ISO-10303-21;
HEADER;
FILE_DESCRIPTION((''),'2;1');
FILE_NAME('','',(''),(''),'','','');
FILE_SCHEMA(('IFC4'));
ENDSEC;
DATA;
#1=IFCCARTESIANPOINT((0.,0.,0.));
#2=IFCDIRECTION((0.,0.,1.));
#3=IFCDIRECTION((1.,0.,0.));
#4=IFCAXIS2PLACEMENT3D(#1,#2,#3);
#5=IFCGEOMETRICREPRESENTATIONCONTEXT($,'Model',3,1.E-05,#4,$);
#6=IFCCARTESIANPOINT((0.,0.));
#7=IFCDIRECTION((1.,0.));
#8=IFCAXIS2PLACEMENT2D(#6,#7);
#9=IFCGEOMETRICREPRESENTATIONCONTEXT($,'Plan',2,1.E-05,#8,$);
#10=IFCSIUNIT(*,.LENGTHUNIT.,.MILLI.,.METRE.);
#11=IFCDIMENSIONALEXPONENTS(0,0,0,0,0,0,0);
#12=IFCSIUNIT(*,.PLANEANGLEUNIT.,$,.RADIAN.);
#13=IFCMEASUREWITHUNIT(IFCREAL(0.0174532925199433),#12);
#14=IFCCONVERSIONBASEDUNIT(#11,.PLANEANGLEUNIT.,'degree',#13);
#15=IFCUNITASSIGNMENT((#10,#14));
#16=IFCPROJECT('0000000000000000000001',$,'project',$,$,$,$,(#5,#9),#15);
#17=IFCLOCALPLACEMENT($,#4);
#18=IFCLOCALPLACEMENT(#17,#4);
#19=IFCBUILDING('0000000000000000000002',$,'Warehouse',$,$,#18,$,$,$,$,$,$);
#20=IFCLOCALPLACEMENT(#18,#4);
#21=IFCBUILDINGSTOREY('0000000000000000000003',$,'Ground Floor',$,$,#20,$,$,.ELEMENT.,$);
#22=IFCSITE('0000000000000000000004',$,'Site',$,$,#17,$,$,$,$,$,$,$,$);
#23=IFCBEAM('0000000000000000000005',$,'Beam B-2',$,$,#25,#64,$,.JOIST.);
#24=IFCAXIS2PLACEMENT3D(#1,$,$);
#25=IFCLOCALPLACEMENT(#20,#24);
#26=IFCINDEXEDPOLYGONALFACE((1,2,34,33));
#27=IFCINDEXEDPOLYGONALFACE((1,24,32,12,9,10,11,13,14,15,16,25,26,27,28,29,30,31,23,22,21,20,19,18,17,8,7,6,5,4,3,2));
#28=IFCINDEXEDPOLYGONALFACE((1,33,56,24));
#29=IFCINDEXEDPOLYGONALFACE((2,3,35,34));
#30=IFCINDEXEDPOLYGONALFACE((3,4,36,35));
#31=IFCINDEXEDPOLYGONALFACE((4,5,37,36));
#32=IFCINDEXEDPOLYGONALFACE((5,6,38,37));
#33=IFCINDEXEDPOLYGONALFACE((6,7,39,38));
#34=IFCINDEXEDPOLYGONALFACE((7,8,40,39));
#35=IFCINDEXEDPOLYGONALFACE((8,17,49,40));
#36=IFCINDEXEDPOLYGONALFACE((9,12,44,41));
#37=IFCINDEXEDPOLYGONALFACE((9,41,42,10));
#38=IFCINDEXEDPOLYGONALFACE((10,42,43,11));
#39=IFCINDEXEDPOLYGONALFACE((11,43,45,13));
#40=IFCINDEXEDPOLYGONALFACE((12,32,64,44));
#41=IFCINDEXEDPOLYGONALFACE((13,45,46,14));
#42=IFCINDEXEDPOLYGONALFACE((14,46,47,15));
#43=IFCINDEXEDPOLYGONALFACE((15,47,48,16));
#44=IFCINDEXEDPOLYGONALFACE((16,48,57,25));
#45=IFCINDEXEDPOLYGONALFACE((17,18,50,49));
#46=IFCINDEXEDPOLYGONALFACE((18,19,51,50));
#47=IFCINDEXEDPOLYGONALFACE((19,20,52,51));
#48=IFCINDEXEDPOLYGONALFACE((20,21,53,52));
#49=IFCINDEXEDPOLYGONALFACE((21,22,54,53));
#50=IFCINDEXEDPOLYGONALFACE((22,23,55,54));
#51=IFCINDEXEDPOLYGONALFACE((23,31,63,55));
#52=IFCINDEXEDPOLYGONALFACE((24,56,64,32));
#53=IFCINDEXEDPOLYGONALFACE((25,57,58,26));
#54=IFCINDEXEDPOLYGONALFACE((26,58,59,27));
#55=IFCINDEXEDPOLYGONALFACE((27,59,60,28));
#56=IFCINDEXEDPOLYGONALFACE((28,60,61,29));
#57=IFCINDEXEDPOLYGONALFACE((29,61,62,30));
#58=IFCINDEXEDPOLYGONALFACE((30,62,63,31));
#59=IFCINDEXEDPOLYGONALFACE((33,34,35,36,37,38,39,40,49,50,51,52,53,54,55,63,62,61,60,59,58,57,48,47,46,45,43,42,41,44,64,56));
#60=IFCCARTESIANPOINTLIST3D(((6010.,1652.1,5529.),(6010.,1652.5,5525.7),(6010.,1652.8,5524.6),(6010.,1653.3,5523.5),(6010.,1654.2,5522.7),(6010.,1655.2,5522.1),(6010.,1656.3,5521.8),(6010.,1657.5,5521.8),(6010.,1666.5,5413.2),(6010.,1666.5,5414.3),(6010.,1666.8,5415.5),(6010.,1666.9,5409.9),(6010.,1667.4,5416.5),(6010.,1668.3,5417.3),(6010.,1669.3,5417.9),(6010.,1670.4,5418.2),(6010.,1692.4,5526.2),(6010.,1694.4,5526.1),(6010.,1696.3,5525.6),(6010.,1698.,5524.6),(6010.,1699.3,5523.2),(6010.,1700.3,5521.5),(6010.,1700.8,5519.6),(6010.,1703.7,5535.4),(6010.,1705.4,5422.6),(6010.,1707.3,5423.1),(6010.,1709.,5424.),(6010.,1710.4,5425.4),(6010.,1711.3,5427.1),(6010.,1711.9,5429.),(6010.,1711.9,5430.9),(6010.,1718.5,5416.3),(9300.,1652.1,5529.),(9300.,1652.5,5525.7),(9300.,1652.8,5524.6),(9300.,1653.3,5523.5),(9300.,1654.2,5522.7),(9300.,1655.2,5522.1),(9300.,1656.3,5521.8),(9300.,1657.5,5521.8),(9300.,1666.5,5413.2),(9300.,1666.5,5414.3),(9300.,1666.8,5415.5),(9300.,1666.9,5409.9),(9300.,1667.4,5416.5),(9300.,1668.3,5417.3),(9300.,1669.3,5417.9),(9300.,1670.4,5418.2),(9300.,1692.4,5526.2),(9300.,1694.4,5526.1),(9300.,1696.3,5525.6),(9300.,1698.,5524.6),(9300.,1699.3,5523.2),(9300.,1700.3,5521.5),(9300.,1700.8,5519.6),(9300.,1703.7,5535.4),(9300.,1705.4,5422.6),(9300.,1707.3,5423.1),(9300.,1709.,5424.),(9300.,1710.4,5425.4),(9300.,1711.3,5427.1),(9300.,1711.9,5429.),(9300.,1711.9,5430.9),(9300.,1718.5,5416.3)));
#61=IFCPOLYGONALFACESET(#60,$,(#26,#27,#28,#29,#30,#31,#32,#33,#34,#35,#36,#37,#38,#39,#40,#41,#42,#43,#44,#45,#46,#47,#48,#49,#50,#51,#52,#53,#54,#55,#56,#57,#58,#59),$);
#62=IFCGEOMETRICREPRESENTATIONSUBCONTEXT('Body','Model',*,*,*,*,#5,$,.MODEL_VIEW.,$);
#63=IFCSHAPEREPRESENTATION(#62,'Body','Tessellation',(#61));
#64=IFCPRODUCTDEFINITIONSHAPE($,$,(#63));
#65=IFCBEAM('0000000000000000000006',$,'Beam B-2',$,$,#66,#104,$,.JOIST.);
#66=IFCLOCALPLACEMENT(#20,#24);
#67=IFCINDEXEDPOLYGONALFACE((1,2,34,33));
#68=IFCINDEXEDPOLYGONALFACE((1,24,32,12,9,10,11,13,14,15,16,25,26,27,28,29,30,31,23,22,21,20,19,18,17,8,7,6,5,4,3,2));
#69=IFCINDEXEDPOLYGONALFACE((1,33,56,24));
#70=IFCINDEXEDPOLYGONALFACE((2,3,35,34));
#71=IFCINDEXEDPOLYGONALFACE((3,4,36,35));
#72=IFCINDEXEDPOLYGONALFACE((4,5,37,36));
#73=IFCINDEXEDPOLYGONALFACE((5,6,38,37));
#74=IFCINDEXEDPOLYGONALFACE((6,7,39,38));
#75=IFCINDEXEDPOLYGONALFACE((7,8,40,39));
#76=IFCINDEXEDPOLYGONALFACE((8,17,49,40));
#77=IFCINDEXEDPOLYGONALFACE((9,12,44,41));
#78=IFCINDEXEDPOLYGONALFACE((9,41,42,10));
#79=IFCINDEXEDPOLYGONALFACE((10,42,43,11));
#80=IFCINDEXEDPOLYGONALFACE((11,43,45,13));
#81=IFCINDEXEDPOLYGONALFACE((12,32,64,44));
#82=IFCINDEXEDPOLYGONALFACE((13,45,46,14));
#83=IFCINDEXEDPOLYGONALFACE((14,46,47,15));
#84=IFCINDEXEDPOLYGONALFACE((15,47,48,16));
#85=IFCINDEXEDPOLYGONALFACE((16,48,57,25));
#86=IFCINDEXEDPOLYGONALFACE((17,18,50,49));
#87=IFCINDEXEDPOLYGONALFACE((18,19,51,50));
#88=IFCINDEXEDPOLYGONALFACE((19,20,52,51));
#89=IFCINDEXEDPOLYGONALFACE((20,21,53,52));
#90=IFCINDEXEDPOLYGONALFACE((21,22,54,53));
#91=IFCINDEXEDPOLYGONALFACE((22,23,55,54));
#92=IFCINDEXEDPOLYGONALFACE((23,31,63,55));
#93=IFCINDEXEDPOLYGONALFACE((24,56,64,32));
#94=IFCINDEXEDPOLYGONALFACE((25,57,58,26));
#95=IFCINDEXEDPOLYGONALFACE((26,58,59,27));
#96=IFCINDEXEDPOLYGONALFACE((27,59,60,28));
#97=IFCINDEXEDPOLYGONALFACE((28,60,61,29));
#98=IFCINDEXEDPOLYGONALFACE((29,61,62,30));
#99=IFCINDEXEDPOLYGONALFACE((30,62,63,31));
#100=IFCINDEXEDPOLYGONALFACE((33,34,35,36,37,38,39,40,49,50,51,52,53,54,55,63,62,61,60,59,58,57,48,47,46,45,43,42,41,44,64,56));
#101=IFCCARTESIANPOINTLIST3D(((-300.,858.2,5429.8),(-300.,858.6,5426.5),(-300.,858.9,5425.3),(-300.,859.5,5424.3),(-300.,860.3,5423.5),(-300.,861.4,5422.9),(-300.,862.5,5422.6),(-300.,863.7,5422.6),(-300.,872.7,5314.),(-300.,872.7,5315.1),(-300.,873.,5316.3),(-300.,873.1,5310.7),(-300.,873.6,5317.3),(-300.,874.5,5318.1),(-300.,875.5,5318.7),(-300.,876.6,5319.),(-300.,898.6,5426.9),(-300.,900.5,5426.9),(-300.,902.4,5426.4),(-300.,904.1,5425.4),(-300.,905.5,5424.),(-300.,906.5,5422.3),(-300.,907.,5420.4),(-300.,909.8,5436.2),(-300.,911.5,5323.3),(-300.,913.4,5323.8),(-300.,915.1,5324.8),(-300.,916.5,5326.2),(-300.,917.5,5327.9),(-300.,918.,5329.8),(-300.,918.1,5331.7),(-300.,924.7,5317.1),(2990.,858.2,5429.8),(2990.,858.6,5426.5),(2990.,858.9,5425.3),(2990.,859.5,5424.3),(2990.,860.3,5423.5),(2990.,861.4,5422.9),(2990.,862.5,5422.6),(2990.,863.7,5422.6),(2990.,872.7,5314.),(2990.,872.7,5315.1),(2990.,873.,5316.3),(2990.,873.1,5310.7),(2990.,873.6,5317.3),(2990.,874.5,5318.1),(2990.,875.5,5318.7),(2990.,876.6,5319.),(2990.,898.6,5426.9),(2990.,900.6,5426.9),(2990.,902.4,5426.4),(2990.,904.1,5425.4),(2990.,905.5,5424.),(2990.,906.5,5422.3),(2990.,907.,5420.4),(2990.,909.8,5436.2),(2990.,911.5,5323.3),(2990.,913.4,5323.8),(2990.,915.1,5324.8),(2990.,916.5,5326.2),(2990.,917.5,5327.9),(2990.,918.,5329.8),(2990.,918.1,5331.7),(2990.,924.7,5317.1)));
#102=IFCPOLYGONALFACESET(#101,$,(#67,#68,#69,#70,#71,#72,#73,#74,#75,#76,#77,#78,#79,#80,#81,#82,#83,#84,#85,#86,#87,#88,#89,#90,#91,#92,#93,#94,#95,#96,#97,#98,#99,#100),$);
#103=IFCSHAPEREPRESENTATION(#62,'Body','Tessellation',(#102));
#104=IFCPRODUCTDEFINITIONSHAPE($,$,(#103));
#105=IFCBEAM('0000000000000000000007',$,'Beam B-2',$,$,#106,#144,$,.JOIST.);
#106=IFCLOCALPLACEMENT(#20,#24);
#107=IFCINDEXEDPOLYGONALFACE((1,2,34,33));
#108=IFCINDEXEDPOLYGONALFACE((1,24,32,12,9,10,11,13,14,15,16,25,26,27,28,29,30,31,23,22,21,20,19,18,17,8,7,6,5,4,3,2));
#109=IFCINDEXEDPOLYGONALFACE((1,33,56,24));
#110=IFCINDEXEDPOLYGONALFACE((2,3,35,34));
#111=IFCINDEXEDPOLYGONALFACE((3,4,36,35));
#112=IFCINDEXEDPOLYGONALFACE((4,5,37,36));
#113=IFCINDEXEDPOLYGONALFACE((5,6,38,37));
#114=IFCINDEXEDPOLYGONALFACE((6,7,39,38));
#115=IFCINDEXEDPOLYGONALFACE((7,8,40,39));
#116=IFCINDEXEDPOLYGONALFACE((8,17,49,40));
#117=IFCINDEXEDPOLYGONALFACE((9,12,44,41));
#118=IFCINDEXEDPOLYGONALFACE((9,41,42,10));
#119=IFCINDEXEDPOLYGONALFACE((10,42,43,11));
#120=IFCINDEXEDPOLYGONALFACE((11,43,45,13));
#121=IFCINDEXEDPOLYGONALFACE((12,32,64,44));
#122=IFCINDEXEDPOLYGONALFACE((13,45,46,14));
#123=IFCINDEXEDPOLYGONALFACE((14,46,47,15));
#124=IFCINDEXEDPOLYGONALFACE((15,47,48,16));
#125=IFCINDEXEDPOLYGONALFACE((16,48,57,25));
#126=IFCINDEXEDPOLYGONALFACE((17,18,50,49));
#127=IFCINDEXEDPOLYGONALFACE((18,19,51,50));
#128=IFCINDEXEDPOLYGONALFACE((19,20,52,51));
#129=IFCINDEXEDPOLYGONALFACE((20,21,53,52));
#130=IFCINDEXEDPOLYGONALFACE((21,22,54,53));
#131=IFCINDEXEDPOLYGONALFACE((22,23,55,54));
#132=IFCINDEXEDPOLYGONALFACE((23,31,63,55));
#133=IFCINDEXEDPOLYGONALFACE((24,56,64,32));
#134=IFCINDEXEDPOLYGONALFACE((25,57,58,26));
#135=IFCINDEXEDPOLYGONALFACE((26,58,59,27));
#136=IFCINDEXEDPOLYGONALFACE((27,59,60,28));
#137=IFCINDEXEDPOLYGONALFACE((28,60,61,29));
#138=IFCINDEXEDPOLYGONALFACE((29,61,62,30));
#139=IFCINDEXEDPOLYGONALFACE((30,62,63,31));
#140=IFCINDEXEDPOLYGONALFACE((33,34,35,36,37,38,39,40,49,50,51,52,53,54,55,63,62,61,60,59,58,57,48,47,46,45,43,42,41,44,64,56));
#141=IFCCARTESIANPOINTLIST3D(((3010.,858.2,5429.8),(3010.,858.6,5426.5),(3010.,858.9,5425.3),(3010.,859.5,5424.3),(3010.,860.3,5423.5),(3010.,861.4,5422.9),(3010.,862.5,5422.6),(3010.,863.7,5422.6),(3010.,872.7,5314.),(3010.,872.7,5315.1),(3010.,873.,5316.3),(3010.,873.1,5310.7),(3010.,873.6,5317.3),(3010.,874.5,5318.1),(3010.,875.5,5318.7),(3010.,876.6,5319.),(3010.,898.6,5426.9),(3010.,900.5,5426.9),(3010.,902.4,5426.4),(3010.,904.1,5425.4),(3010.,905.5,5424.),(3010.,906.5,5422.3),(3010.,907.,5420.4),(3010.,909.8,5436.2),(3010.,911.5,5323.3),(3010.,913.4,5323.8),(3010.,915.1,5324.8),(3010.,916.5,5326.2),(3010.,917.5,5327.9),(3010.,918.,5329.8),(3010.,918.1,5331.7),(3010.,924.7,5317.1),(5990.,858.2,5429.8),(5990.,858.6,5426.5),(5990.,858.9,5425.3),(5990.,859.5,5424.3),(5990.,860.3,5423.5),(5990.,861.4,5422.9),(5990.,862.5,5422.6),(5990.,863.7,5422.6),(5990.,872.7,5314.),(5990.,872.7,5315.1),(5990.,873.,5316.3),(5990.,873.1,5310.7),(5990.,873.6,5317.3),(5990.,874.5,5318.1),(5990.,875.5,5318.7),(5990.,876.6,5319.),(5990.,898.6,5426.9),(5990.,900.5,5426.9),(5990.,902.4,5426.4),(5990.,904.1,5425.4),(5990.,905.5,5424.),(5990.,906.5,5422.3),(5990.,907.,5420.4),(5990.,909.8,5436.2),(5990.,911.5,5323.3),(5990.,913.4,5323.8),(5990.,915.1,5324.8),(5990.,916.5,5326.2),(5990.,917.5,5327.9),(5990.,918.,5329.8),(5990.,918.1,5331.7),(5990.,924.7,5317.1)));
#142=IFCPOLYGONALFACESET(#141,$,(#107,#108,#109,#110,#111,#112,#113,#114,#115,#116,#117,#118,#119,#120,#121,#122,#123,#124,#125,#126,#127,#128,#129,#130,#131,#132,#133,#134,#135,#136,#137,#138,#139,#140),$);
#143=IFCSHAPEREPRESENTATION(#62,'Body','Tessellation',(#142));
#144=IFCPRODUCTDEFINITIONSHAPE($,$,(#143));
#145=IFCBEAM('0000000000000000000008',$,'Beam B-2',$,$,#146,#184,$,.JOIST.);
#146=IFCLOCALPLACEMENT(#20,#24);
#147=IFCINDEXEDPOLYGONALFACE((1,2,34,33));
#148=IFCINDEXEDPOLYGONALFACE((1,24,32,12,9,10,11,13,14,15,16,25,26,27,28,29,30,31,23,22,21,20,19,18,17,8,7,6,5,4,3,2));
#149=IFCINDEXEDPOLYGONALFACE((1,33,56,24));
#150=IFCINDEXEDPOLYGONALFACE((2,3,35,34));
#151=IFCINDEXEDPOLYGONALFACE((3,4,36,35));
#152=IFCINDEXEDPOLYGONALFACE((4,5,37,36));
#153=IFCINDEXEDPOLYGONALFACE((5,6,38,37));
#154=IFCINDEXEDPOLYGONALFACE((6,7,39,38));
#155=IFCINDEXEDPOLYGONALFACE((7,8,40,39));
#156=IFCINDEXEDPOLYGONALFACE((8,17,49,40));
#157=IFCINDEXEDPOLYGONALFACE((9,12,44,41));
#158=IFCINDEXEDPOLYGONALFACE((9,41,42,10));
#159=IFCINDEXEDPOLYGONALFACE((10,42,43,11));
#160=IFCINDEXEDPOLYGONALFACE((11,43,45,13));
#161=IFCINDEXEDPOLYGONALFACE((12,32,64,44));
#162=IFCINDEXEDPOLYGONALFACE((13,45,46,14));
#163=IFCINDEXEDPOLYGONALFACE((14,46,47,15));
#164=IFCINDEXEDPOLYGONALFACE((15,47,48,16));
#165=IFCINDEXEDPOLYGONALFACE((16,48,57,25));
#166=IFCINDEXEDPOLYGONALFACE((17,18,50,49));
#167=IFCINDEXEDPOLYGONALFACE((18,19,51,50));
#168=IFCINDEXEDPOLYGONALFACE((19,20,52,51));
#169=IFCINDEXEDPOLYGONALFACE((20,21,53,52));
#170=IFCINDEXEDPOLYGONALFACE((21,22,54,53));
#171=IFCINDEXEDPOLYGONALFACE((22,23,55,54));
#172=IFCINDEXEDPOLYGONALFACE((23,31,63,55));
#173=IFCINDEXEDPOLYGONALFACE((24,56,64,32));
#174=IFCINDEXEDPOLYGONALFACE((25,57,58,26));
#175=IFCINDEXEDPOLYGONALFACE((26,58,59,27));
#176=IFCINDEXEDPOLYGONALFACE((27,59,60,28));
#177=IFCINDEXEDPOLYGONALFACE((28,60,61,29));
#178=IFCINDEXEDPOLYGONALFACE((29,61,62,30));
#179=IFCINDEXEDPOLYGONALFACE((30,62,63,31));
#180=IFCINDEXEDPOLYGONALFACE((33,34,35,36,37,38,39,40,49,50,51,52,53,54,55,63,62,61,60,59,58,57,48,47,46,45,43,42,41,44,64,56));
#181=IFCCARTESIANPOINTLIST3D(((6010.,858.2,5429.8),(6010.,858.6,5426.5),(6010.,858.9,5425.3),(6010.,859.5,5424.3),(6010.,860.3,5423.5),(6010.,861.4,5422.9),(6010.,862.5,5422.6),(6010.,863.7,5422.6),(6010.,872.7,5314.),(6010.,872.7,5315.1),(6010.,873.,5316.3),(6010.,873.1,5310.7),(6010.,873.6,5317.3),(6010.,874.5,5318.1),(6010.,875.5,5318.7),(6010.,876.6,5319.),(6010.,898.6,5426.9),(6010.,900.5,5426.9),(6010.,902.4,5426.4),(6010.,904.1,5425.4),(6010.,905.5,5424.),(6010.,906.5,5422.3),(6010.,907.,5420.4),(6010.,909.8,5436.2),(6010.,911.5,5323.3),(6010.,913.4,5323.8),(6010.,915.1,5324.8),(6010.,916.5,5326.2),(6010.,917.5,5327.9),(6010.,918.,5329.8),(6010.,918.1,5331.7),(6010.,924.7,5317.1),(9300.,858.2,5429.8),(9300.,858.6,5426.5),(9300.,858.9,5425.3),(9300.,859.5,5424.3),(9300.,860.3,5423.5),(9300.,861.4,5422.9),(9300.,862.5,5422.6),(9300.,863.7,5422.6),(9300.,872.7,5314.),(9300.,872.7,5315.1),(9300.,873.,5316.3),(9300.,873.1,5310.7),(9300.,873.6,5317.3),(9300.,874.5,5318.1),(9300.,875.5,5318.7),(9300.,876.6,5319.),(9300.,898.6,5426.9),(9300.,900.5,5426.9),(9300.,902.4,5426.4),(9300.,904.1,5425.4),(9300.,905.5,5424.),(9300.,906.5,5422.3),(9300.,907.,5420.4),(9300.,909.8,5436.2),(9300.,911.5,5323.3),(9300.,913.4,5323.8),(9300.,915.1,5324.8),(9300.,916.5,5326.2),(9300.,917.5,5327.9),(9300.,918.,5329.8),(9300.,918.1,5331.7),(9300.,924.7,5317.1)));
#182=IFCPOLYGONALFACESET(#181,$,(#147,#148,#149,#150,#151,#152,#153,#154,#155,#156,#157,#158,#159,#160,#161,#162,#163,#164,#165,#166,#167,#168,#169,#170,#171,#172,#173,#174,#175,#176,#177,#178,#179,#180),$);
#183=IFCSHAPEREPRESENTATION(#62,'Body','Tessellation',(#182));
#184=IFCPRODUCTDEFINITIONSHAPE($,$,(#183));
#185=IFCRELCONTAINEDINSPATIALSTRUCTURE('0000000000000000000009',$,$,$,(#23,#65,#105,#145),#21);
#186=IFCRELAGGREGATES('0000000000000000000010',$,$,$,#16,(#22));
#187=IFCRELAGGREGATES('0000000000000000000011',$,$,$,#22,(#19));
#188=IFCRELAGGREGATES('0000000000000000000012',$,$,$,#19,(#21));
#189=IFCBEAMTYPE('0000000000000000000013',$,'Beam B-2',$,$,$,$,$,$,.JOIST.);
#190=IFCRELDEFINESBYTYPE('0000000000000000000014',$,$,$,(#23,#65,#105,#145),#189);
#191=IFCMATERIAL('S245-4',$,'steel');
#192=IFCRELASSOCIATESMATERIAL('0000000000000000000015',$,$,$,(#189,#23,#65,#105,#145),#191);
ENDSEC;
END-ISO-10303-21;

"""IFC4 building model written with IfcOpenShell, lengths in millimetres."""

from ifc_helpers import new_model, entity, si_unit, converted_unit, frame, origin_with_axes, origin_2d_with_axis, place, context, subcontext, project, spatial, u_section, extrude, material, material_profile, profile_set, profile_usage, type_object, element, save


model = new_model("IFC4")

# Units and contexts
model_context = context("Model", 3, precision=1e-05, world=origin_with_axes())
plan_context = context("Plan", 2, precision=1e-05, world=origin_2d_with_axis())
body_context = subcontext(model_context, "Body", "Model", "MODEL_VIEW")
ifc_project = project(units=[si_unit("LENGTHUNIT", "METRE", prefix="MILLI"), converted_unit("PLANEANGLEUNIT", "degree", entity("IfcReal", 0.0174532925199433), si_unit("PLANEANGLEUNIT", "RADIAN"), dimensions=[0, 0, 0, 0, 0, 0, 0])], contexts=[model_context, plan_context])

# Site, building, storey
site_placement = place(None, origin_with_axes())
site = spatial("IfcSite", under=ifc_project, at=site_placement, Name="Site")
building_placement = place(site_placement, origin_with_axes())
building = spatial("IfcBuilding", under=site, at=building_placement, Name="Warehouse")
storey_placement = place(building_placement, origin_with_axes())
storey = spatial("IfcBuildingStorey", under=building, at=storey_placement, Name="Ground Floor", CompositionType="ELEMENT")

# Beams
ifc_material_1 = material(Name="S245-4", Category="steel")
ifc_material_profile_1 = material_profile(ifc_material_1, u_section(Depth=120.0, FlangeWidth=52.0, WebThickness=4.8, FlangeThickness=7.8, FilletRadius=7.5, EdgeRadius=4.5, FlangeSlope=0.0))
ifc_profile_set_1 = profile_set([ifc_material_profile_1], Name="U12P_S245-4")
beam_type_1 = type_object("IfcBeamType", Name="Beam B-2", PredefinedType="JOIST", material=ifc_profile_set_1)
ifc_profile_usage_1 = profile_usage(ifc_profile_set_1, cardinal=3)
beam_1_placement = place(storey_placement, frame((9300.0, 1718.5, 5416.3), z_axis=(-1.0, 0.0, 0.0), x_axis=(0.0, -0.99228, -0.12402)))
element("IfcBeam", 1, at=beam_1_placement, inside=storey, type_object=beam_type_1, material=ifc_profile_usage_1, Name="Beam B-2", PredefinedType="JOIST", context=body_context, shape_type="SweptSolid", body=[
    extrude(u_section(Depth=120.0, FlangeWidth=52.0, WebThickness=4.8, FlangeThickness=7.8, FilletRadius=7.5, EdgeRadius=4.5, FlangeSlope=0.0), frame((26.0, 60.0, 0.0), z_axis=(0.0, 0.0, 1.0), x_axis=(1.0, 0.0, 0.0)), (0.0, 0.0, 1.0), 3290.0),
])
ifc_profile_usage_2 = profile_usage(ifc_profile_set_1, cardinal=3)
beam_2_placement = place(storey_placement, frame((2990.0, 924.7, 5317.1), z_axis=(-1.0, 0.0, 0.0), x_axis=(0.0, -0.99228, -0.124019)))
element("IfcBeam", 2, at=beam_2_placement, inside=storey, type_object=beam_type_1, material=ifc_profile_usage_2, Name="Beam B-2", PredefinedType="JOIST", context=body_context, shape_type="SweptSolid", body=[
    extrude(u_section(Depth=120.0, FlangeWidth=52.0, WebThickness=4.8, FlangeThickness=7.8, FilletRadius=7.5, EdgeRadius=4.5, FlangeSlope=0.0), frame((26.0, 60.0, 0.0), z_axis=(0.0, 0.0, 1.0), x_axis=(1.0, 0.0, 0.0)), (0.0, 0.0, 1.0), 3290.0),
])
ifc_profile_usage_3 = profile_usage(ifc_profile_set_1, cardinal=3)
beam_3_placement = place(storey_placement, frame((5990.0, 924.7, 5317.1), z_axis=(-1.0, 0.0, 0.0), x_axis=(0.0, -0.99228, -0.12402)))
element("IfcBeam", 3, at=beam_3_placement, inside=storey, type_object=beam_type_1, material=ifc_profile_usage_3, Name="Beam B-2", PredefinedType="JOIST", context=body_context, shape_type="SweptSolid", body=[
    extrude(u_section(Depth=120.0, FlangeWidth=52.0, WebThickness=4.8, FlangeThickness=7.8, FilletRadius=7.5, EdgeRadius=4.5, FlangeSlope=0.0), frame((26.0, 60.0, 0.0), z_axis=(0.0, 0.0, 1.0), x_axis=(1.0, 0.0, 0.0)), (0.0, 0.0, 1.0), 2980.0),
])
ifc_profile_usage_4 = profile_usage(ifc_profile_set_1, cardinal=3)
beam_4_placement = place(storey_placement, frame((9300.0, 924.7, 5317.1), z_axis=(-1.0, 0.0, 0.0), x_axis=(0.0, -0.99228, -0.12402)))
element("IfcBeam", 4, at=beam_4_placement, inside=storey, type_object=beam_type_1, material=ifc_profile_usage_4, Name="Beam B-2", PredefinedType="JOIST", context=body_context, shape_type="SweptSolid", body=[
    extrude(u_section(Depth=120.0, FlangeWidth=52.0, WebThickness=4.8, FlangeThickness=7.8, FilletRadius=7.5, EdgeRadius=4.5, FlangeSlope=0.0), frame((26.0, 60.0, 0.0), z_axis=(0.0, 0.0, 1.0), x_axis=(1.0, 0.0, 0.0)), (0.0, 0.0, 1.0), 3290.0),
])

save(model, "model.ifc")
